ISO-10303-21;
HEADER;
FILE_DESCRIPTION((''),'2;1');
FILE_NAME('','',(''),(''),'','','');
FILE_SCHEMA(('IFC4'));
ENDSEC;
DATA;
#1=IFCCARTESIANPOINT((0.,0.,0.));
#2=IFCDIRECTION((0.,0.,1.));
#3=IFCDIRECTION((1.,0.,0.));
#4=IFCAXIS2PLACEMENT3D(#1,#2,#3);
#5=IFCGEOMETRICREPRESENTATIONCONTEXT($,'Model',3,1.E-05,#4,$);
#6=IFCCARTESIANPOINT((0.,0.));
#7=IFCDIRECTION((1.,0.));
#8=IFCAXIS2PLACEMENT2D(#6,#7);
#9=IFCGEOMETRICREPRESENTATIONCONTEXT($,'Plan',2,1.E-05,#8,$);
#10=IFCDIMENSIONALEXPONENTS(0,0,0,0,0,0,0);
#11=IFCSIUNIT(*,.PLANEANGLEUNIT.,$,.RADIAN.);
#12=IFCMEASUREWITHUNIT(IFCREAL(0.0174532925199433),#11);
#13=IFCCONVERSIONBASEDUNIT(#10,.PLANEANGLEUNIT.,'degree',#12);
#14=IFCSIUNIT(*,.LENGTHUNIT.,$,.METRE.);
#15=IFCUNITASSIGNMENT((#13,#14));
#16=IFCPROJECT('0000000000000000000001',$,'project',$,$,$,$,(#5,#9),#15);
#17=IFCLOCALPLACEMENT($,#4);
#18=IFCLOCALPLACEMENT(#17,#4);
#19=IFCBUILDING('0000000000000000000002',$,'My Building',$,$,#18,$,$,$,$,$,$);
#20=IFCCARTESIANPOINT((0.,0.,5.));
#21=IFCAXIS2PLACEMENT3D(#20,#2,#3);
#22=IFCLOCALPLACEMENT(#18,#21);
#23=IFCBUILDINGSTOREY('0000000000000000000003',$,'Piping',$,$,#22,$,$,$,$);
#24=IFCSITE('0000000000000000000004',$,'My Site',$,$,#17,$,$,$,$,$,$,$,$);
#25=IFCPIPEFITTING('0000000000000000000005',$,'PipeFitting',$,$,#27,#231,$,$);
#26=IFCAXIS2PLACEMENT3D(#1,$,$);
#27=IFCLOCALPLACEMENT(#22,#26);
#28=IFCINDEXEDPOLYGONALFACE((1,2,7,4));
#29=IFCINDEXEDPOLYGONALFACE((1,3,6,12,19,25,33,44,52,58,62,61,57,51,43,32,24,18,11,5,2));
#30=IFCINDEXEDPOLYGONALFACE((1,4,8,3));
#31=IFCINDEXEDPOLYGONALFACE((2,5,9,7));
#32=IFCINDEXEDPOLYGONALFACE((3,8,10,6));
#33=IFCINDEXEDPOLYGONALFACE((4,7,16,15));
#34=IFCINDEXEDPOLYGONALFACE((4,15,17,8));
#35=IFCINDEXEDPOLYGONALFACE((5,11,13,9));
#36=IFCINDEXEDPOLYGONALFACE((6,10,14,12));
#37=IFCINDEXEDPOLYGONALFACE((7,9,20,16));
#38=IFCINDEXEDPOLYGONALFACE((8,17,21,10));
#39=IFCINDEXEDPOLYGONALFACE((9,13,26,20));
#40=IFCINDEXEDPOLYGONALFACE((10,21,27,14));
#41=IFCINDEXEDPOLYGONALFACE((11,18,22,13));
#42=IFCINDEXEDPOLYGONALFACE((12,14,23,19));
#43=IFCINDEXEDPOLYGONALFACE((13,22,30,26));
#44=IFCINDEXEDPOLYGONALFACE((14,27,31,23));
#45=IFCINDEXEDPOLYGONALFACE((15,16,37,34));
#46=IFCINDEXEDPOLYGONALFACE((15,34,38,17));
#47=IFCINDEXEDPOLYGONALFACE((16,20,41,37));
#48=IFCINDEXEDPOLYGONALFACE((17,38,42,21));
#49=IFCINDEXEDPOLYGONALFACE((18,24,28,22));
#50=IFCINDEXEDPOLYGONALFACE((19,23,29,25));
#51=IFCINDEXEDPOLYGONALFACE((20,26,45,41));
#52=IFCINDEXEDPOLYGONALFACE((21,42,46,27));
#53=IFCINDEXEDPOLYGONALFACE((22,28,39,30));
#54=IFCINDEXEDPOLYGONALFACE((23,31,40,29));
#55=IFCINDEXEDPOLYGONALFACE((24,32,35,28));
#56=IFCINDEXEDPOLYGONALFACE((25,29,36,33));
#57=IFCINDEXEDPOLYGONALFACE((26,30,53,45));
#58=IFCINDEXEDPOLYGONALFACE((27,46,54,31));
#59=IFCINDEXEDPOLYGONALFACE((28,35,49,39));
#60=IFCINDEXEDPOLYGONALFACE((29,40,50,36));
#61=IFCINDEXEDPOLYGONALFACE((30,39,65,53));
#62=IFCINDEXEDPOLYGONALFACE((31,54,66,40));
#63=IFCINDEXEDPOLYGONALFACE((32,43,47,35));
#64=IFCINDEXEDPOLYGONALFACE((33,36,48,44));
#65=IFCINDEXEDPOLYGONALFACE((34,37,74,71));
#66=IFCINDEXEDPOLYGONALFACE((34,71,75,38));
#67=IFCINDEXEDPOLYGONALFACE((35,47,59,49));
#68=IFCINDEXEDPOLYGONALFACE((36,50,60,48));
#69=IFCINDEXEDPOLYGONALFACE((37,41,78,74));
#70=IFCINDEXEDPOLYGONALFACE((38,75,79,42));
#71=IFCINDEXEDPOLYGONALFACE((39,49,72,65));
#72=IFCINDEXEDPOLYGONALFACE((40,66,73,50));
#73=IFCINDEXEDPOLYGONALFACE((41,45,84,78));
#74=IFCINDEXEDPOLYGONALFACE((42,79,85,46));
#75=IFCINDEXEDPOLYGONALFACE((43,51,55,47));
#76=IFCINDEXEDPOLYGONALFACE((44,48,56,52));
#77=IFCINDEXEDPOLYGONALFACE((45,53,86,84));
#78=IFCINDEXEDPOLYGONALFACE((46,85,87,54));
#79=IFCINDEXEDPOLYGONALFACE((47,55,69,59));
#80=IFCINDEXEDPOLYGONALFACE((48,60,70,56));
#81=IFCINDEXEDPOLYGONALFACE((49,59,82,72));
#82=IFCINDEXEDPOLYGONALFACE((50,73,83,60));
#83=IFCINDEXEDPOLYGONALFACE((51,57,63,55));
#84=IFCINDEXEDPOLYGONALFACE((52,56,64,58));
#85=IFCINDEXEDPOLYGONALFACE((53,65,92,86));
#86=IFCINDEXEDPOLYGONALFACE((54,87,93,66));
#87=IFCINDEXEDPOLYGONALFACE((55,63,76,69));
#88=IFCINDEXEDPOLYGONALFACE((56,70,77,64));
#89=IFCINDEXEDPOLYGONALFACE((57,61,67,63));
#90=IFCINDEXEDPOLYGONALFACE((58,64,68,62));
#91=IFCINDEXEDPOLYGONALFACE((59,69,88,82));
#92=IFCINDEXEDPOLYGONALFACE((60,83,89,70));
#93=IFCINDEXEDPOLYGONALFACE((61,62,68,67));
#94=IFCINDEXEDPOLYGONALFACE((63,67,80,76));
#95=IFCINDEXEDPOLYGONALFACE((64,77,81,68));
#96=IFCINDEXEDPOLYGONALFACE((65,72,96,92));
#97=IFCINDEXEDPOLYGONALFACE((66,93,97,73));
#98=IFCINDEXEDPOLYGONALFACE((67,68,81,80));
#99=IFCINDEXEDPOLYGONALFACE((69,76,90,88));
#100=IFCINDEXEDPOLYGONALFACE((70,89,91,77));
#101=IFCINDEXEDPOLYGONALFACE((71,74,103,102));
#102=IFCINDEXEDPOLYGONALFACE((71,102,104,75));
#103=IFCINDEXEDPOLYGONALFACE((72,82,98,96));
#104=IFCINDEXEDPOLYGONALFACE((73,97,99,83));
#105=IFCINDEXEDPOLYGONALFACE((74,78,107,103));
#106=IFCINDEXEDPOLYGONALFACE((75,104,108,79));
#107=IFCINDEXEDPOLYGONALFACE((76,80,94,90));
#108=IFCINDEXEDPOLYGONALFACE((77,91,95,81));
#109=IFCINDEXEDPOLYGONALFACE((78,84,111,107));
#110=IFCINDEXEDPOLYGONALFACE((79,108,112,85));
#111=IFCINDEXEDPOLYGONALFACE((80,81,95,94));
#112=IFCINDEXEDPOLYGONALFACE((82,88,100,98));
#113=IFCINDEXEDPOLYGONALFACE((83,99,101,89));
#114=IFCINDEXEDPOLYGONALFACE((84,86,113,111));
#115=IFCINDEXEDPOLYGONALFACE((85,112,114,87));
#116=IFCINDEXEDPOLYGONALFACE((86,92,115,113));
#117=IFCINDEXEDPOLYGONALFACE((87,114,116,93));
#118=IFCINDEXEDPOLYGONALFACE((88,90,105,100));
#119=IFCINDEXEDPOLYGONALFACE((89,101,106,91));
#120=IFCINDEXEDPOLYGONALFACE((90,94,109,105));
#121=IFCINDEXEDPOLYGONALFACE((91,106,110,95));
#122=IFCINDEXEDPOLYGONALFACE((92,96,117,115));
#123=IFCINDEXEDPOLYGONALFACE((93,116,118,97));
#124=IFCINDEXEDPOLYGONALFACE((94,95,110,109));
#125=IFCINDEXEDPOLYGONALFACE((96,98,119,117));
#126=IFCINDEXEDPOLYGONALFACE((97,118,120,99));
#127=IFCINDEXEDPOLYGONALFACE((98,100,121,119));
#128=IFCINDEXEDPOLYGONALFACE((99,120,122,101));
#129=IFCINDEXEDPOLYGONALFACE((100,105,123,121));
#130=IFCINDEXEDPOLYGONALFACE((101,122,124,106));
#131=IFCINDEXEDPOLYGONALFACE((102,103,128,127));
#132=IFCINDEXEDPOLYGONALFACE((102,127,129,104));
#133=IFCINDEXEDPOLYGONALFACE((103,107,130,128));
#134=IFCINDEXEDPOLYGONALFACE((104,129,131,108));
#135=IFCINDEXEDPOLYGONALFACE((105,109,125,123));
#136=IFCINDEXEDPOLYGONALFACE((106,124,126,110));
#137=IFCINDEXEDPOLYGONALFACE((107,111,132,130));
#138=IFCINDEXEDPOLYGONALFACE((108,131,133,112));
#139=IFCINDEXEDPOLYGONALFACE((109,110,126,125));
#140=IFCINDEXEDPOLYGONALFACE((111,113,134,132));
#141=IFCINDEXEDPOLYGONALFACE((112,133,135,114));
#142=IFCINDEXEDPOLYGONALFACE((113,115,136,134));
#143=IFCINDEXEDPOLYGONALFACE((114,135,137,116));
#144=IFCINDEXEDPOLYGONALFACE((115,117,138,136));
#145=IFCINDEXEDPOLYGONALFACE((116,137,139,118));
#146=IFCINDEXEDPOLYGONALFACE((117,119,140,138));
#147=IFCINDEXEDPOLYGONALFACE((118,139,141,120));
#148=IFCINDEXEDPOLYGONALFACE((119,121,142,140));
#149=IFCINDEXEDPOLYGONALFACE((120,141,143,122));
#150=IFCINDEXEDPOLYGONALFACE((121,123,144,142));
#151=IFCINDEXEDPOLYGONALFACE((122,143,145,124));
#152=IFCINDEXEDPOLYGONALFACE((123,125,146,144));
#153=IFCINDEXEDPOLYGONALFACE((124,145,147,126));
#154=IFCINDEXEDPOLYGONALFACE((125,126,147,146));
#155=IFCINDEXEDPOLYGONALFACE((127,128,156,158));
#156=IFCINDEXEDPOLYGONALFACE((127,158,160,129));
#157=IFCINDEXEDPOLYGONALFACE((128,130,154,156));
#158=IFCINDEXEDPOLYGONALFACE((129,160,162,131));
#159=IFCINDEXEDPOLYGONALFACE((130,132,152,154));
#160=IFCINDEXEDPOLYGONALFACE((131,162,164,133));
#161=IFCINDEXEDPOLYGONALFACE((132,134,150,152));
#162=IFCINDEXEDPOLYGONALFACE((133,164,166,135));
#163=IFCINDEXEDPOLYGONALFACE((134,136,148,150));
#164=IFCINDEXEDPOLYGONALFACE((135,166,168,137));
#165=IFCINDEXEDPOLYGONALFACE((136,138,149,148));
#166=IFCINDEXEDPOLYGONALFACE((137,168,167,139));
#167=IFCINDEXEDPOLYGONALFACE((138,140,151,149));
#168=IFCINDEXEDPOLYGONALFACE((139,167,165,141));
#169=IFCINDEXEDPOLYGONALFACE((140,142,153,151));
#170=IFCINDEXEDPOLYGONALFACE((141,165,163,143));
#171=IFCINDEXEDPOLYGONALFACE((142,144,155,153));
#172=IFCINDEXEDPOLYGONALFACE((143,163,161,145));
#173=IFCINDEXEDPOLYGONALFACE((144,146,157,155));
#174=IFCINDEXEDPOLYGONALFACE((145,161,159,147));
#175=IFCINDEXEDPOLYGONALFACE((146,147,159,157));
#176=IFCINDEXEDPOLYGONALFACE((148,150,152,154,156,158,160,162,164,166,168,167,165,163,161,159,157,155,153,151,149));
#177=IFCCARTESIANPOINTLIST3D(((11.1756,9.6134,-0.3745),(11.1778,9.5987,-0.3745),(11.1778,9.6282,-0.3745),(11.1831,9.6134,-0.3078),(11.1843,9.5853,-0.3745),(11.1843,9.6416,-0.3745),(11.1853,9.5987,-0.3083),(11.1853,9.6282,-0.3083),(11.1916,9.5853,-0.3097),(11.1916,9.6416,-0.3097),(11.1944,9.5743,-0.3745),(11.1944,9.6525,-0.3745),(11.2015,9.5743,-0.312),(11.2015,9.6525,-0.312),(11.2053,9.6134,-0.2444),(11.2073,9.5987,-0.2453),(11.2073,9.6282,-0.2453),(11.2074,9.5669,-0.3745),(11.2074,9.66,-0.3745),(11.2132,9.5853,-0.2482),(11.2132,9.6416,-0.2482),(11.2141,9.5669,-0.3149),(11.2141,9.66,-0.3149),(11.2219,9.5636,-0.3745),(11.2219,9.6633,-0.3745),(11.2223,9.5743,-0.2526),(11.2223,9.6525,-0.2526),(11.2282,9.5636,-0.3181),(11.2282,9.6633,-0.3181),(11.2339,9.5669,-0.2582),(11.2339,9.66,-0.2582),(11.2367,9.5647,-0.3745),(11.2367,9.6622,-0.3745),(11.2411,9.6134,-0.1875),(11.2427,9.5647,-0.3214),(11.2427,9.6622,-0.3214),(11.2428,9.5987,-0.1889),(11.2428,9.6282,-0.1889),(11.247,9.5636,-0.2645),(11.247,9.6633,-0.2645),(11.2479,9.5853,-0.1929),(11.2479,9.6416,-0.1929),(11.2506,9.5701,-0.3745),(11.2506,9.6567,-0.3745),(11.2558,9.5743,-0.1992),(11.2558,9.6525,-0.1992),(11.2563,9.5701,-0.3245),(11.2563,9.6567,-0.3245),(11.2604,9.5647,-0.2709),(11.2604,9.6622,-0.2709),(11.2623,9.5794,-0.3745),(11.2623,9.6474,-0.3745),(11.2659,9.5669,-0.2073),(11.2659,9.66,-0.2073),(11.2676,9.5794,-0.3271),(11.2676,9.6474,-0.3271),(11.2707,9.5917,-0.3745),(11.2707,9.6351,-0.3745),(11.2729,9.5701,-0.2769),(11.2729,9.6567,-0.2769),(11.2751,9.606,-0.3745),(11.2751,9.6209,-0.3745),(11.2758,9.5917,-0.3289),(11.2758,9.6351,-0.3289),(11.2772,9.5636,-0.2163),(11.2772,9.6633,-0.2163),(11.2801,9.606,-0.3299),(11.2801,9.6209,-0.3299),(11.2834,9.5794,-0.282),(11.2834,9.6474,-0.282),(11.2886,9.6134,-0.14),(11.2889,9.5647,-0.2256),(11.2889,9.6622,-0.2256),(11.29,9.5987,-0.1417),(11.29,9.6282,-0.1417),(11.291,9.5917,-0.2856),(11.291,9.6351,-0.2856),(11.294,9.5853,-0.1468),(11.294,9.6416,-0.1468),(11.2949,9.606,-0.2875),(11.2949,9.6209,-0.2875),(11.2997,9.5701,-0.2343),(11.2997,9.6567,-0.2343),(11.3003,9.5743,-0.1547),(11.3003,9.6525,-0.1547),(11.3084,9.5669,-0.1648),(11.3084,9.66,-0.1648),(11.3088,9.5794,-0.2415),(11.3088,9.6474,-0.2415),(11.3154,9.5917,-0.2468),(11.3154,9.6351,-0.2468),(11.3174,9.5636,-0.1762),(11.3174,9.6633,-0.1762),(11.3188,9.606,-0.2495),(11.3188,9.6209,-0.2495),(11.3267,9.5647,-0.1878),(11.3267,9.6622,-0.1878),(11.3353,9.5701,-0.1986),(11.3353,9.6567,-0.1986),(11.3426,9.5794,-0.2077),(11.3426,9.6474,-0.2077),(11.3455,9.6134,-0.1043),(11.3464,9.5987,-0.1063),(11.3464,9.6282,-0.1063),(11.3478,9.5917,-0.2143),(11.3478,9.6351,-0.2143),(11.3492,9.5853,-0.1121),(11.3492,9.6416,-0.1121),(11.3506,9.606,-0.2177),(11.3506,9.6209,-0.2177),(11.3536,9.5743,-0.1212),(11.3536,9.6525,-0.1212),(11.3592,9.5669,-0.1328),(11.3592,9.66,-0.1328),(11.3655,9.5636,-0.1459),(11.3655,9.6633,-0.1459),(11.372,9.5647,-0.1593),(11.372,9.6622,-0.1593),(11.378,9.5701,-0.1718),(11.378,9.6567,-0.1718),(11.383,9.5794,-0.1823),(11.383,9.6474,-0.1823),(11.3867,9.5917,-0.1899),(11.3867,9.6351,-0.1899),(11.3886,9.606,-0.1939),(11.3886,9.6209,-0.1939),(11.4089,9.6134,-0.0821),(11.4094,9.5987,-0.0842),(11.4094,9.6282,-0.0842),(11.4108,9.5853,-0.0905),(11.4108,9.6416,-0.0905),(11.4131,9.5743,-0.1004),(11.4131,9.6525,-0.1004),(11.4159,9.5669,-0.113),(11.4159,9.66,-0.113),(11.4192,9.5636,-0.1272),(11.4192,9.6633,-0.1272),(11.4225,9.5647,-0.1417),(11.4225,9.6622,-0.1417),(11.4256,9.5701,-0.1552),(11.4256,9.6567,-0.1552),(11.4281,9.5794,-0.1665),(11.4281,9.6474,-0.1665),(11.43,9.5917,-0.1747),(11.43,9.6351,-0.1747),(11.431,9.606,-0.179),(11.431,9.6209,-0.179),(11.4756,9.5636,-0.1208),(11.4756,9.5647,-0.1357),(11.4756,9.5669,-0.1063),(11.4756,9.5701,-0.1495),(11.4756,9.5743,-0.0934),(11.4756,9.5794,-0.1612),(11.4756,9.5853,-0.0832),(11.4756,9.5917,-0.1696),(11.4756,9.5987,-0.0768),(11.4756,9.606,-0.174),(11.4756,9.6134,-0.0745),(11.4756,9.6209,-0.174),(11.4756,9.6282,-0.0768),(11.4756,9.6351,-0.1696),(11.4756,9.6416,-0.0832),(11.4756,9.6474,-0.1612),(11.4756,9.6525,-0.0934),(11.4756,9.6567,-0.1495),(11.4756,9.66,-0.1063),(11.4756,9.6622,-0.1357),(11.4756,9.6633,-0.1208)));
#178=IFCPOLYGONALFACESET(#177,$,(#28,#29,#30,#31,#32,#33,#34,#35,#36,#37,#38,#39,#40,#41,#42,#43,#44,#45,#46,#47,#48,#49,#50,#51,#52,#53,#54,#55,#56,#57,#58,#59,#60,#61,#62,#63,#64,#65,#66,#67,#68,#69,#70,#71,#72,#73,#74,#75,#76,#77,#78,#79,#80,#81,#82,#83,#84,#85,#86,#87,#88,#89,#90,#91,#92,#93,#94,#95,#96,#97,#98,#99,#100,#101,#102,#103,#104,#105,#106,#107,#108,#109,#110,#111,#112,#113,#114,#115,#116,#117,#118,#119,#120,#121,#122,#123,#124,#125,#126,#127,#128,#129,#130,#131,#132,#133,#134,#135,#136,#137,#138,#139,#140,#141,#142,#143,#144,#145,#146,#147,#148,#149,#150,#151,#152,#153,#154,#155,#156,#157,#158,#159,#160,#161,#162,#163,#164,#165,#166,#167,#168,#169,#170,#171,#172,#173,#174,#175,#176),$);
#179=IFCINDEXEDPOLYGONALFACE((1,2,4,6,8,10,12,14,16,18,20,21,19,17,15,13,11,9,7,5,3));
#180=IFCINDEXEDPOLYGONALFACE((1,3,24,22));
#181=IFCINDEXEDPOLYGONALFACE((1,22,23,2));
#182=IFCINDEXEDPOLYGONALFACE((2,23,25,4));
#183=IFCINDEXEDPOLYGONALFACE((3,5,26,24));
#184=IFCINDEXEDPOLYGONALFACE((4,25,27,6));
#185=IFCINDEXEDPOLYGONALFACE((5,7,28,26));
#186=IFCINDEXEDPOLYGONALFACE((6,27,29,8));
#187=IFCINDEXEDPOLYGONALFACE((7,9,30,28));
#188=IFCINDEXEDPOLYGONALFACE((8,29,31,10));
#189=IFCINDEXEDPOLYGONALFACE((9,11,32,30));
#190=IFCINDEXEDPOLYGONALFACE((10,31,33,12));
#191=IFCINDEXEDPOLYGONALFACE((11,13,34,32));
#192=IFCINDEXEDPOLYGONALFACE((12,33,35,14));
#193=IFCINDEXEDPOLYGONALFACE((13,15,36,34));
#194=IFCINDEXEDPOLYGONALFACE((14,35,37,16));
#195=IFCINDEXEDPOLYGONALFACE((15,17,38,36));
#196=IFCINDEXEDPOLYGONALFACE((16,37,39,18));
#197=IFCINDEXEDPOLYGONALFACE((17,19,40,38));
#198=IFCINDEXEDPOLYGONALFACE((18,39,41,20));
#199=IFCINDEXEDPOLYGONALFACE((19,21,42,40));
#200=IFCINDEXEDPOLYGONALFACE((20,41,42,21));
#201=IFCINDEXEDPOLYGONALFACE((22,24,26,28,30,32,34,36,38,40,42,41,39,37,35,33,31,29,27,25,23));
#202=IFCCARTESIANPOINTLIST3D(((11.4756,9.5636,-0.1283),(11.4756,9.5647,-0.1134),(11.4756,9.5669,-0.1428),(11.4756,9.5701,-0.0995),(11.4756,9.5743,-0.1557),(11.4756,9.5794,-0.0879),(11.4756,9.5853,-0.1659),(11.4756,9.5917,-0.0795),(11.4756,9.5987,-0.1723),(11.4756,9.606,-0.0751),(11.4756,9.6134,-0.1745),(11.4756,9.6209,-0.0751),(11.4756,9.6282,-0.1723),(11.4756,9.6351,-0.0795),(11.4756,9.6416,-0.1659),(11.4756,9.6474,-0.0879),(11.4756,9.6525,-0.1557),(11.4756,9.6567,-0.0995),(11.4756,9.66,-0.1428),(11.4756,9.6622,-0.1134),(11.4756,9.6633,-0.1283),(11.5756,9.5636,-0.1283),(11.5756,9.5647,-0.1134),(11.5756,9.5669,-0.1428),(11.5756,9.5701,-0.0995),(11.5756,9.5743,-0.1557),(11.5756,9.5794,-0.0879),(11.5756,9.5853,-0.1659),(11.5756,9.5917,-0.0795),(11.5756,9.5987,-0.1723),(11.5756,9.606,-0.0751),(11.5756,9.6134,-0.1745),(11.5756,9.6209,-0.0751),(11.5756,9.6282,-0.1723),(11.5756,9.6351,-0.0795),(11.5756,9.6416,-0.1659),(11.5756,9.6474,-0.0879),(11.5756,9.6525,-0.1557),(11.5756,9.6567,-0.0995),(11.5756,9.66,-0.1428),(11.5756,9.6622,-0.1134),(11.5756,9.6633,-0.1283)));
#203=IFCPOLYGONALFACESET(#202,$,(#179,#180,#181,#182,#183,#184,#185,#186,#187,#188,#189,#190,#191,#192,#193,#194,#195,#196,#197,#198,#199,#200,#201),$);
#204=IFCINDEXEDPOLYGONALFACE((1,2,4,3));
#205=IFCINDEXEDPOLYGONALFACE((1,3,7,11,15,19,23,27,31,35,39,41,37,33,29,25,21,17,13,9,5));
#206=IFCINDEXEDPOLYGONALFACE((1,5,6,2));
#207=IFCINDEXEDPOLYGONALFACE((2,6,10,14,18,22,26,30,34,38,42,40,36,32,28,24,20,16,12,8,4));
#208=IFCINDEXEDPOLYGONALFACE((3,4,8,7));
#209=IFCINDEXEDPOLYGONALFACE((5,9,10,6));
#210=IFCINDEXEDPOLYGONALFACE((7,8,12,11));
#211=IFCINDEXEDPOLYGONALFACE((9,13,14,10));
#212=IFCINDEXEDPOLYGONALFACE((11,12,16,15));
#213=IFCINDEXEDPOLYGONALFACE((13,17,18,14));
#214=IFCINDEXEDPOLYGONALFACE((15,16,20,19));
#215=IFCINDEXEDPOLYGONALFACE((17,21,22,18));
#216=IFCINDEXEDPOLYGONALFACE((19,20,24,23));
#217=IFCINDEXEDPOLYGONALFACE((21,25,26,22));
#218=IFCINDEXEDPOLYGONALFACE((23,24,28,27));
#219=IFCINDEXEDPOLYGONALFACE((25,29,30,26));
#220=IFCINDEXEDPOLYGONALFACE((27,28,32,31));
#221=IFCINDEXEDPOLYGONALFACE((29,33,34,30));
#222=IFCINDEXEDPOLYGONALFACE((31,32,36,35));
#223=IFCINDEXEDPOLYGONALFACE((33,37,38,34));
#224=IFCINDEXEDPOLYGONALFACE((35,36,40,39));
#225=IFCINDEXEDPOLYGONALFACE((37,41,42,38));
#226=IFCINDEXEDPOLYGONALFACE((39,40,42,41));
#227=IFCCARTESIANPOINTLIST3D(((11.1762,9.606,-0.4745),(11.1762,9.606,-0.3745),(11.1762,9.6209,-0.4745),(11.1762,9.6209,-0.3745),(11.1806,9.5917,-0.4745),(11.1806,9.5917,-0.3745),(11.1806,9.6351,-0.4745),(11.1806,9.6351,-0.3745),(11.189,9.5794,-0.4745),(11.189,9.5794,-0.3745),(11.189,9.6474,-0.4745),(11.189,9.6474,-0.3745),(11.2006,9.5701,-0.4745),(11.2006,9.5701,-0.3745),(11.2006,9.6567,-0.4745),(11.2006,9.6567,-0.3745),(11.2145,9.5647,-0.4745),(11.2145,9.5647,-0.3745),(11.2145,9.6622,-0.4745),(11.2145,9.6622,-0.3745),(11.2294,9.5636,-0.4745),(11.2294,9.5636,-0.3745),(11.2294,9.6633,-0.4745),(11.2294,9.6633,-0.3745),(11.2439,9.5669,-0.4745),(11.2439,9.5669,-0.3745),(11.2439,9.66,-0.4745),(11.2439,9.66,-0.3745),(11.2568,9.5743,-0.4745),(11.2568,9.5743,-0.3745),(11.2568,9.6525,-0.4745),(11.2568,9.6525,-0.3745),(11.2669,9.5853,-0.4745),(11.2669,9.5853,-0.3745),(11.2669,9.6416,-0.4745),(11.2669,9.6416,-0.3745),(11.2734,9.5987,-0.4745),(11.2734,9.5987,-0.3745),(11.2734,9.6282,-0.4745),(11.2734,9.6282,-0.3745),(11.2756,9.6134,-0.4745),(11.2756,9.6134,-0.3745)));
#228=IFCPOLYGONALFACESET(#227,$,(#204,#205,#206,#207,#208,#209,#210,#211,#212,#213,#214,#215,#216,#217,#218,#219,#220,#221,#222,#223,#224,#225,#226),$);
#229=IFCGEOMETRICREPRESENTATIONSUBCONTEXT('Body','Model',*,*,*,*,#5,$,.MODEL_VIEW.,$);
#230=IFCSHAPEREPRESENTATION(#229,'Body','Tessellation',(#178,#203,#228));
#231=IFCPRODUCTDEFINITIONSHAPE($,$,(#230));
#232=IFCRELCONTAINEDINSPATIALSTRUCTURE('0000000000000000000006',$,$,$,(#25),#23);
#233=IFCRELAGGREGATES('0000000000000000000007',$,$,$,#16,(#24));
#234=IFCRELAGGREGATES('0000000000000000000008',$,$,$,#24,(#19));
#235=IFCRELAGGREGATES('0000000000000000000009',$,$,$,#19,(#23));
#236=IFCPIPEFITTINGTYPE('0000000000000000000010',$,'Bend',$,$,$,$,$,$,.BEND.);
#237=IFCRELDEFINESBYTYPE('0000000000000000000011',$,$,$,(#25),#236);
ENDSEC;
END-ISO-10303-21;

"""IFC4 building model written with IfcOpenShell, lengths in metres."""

from ifc_helpers import new_model, entity, si_unit, converted_unit, frame, origin_with_axes, origin_2d_with_axis, place, context, subcontext, project, spatial, circle, extrude, source, transform, mapped, type_object, type_shapes, element, save


model = new_model("IFC4")

# Units and contexts
model_context = context("Model", 3, precision=1e-05, world=origin_with_axes())
plan_context = context("Plan", 2, precision=1e-05, world=origin_2d_with_axis())
body_context = subcontext(model_context, "Body", "Model", "MODEL_VIEW")
ifc_project = project(units=[converted_unit("PLANEANGLEUNIT", "degree", entity("IfcReal", 0.0174532925199433), si_unit("PLANEANGLEUNIT", "RADIAN"), dimensions=[0, 0, 0, 0, 0, 0, 0]), si_unit("LENGTHUNIT", "METRE")], contexts=[model_context, plan_context])

# Site, building, storey
site_placement = place(None, origin_with_axes())
site = spatial("IfcSite", under=ifc_project, at=site_placement, Name="My Site")
building_placement = place(site_placement, origin_with_axes())
building = spatial("IfcBuilding", under=site, at=building_placement, Name="My Building")
storey_placement = place(building_placement, frame((0.0, 0.0, 5.0), z_axis=(0.0, 0.0, 1.0), x_axis=(1.0, 0.0, 0.0)))
storey = spatial("IfcBuildingStorey", under=building, at=storey_placement, Name="Piping")

# Pipe fitting
pipe_fitting_type_1 = type_object("IfcPipeFittingType", Name="Bend", PredefinedType="BEND")
shared_shape = source(origin_with_axes(), body_context, "Body", "SolidModel", [
    entity("IfcSweptDiskSolid", entity("IfcIndexedPolyCurve", entity("IfcCartesianPointList3D", [[0.0, 0.0, -0.1], [0.0732, 0.0, -0.2768], [0.25, 0.0, -0.35]]), [entity("IfcArcIndex", [1, 2, 3])]), 0.05),
    extrude(circle(Radius=0.05), origin_with_axes(), (0.0, 0.0, -1.0), 0.1),
    extrude(circle(Radius=0.05), frame((0.25, 0.0, -0.35), z_axis=(1.0, 0.0, 0.0), x_axis=(0.0, 0.0, 1.0)), (0.0, 0.0, 1.0), 0.1),
])
type_shapes(pipe_fitting_type_1, [shared_shape])
for number, where, z_axis, x_axis, name in (
    (1, (11.5756, 9.6134, -0.1245), (1.0, 0.000001, 0.0), (0.0, 0.0, -1.0), "PipeFitting"),
):
    element("IfcPipeFitting", number, at=place(storey_placement, frame(where, z_axis=z_axis, x_axis=x_axis)), inside=storey, type_object=pipe_fitting_type_1, Name=name, context=body_context, shape_type="MappedRepresentation", body=[
        mapped(shared_shape, transform((0.0, 0.0, 0.0), x_axis=(1.0, 0.0, 0.0), y_axis=(0.0, 1.0, 0.0), z_axis=(0.0, 0.0, 1.0), scale=1.0)),
    ])

save(model, "model.ifc")
